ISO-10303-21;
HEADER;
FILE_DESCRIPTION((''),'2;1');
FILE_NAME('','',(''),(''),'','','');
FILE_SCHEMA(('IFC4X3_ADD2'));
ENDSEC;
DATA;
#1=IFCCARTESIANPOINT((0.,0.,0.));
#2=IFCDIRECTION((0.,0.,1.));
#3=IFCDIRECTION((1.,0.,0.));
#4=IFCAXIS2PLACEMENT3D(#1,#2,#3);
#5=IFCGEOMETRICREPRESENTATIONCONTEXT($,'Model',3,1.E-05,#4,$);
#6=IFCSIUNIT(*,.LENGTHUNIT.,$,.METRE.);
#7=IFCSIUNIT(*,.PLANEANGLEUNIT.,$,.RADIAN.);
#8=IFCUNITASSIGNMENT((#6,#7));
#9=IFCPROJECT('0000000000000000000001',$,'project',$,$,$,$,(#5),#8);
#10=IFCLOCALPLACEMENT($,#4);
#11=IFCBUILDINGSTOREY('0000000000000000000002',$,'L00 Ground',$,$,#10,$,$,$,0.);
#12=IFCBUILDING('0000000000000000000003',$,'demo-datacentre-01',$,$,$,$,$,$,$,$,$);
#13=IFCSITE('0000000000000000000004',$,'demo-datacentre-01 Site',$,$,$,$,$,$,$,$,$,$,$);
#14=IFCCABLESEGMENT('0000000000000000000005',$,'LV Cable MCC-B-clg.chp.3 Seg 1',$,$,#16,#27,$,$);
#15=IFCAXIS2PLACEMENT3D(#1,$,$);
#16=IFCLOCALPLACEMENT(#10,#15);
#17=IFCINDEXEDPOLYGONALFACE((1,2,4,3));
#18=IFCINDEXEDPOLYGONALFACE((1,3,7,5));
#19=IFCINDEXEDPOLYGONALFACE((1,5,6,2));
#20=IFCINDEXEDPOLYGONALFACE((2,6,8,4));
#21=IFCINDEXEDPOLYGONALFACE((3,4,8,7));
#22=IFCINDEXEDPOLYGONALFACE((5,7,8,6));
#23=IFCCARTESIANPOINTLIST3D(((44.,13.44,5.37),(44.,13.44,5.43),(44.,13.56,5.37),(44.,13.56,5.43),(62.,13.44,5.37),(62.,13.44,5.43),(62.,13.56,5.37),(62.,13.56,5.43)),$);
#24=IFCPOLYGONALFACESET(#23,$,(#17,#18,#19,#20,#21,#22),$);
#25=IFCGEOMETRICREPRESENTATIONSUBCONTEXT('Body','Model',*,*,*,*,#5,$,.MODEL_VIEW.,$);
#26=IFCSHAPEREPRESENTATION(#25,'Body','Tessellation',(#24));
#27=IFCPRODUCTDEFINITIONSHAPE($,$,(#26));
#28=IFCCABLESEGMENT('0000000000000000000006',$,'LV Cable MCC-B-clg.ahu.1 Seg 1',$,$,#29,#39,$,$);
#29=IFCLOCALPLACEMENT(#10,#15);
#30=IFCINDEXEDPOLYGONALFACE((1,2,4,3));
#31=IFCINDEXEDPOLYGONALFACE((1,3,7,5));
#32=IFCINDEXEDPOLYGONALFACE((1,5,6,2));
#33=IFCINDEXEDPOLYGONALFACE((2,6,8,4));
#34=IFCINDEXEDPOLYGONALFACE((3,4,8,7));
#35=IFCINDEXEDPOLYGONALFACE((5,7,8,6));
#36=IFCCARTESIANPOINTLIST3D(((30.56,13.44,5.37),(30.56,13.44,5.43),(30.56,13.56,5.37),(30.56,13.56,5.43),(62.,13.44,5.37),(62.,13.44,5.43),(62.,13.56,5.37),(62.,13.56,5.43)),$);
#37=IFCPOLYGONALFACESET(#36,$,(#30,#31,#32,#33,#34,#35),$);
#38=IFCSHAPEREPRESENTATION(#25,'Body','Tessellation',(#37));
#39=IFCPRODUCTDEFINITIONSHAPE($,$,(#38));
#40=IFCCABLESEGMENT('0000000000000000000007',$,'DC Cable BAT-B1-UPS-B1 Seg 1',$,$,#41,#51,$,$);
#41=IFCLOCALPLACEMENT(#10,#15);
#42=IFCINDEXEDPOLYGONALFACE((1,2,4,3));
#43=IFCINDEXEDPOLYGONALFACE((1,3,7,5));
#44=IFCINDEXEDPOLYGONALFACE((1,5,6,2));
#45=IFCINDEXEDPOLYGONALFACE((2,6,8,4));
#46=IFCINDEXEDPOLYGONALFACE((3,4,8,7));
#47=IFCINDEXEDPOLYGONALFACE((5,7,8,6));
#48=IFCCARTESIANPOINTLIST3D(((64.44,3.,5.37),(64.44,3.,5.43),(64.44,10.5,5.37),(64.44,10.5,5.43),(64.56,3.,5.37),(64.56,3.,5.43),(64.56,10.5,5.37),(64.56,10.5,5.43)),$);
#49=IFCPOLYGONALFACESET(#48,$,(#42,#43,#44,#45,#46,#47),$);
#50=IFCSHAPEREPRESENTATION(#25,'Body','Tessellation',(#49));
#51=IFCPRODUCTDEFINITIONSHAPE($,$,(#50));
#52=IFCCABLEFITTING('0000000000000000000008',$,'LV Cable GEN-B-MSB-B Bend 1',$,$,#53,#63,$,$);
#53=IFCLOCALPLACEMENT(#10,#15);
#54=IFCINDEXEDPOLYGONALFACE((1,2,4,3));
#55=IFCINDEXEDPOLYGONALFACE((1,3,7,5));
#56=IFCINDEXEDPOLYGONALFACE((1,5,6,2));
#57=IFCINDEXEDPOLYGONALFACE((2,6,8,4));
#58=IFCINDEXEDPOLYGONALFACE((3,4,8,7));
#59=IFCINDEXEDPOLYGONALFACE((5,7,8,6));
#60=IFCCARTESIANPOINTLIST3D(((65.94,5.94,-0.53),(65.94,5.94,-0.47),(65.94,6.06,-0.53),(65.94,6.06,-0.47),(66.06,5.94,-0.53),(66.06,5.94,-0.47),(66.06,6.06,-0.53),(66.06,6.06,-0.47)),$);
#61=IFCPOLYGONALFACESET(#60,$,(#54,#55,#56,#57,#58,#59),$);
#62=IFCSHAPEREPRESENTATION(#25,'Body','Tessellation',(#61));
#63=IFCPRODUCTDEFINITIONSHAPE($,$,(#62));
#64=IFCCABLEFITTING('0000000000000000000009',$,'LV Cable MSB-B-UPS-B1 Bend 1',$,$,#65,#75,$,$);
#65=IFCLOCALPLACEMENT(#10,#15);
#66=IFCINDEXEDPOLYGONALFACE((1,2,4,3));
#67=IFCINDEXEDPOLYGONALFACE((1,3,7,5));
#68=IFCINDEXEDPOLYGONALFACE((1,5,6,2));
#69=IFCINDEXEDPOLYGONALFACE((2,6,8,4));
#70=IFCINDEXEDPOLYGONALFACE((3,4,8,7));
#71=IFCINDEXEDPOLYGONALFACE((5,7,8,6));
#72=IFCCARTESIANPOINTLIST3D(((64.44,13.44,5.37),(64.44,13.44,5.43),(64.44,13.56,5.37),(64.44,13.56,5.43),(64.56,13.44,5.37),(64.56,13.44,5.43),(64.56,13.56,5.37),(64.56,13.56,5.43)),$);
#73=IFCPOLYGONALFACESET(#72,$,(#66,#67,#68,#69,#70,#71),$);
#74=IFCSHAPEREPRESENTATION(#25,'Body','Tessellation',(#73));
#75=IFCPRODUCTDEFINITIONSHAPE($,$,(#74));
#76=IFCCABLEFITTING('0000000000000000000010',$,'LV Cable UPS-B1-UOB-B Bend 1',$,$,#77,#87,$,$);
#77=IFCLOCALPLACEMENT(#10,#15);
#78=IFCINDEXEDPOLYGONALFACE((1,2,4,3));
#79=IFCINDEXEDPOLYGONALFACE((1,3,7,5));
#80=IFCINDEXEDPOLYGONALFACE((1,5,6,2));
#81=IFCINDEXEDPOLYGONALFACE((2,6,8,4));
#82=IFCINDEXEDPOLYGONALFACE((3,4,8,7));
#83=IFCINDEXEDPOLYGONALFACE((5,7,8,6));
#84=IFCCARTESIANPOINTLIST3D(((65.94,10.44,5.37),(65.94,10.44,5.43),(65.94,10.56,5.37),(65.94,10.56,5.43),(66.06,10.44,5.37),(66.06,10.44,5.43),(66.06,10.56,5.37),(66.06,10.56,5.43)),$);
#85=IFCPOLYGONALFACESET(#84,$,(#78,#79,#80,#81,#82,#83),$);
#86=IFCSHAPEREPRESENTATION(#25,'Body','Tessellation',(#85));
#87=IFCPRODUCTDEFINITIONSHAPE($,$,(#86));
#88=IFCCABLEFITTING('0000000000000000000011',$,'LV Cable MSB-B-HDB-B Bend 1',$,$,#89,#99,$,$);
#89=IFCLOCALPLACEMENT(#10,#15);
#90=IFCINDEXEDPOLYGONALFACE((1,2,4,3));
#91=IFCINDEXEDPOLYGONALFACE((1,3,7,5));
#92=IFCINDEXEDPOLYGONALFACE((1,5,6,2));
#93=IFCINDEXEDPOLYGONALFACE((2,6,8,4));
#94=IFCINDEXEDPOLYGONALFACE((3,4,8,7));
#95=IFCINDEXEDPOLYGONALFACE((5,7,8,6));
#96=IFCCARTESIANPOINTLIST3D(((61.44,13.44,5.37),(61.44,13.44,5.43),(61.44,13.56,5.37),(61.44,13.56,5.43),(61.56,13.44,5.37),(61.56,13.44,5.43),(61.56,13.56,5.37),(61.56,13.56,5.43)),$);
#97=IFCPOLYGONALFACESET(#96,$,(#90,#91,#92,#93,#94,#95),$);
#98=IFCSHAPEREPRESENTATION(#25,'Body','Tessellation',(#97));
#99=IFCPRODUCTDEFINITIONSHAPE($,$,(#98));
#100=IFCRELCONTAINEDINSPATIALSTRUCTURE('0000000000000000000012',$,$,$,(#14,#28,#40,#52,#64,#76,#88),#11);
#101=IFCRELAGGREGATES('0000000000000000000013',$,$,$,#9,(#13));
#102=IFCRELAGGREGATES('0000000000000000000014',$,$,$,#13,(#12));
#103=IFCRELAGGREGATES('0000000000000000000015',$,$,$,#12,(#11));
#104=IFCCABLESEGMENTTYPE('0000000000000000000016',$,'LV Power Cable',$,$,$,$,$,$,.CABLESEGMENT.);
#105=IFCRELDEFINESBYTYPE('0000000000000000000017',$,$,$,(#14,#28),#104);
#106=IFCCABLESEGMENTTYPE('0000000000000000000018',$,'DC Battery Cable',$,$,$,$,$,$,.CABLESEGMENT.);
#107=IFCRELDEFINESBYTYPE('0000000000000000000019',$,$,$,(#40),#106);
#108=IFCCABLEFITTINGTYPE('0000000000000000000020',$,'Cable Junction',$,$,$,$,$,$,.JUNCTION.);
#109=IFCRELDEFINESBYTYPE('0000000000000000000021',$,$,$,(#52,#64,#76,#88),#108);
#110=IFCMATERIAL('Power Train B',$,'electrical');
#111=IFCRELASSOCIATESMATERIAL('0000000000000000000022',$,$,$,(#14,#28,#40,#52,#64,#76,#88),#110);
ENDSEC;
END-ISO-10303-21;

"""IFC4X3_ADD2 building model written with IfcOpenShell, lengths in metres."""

from ifc_helpers import new_model, si_unit, frame, origin_with_axes, place, context, subcontext, project, spatial, rectangle, extrude, material, type_object, element, save


model = new_model("IFC4X3_ADD2")

# Units and contexts
model_context = context("Model", 3, precision=1e-05, world=origin_with_axes())
body_context = subcontext(model_context, "Body", "Model", "MODEL_VIEW")
ifc_project = project(units=[si_unit("LENGTHUNIT", "METRE"), si_unit("PLANEANGLEUNIT", "RADIAN")], contexts=[model_context])

# Site, building, storey
site = spatial("IfcSite", under=ifc_project, Name="demo-datacentre-01 Site")
building = spatial("IfcBuilding", under=site, Name="demo-datacentre-01")
storey_placement = place(None, origin_with_axes())
storey = spatial("IfcBuildingStorey", under=building, at=storey_placement, Name="L00 Ground", Elevation=0.0)

# Shared definitions
ifc_material = material(Name="Power Train B", Category="electrical")

# Cable segments
cable_segment_type_1 = type_object("IfcCableSegmentType", Name="LV Power Cable", PredefinedType="CABLESEGMENT")
cable_segment_1_placement = place(storey_placement, frame((62.0, 13.5, 5.4), z_axis=(-1.0, 0.0, 0.0), x_axis=(0.0, -1.0, 0.0)))
element("IfcCableSegment", 1, at=cable_segment_1_placement, inside=storey, type_object=cable_segment_type_1, material=ifc_material, Name="LV Cable MCC-B-clg.chp.3 Seg 1", context=body_context, shape_type="SweptSolid", body=[
    extrude(rectangle(XDim=0.12, YDim=0.06), origin_with_axes(), (0.0, 0.0, 1.0), 18.0),
])
cable_segment_2_placement = place(storey_placement, frame((62.0, 13.5, 5.4), z_axis=(-1.0, 0.0, 0.0), x_axis=(0.0, -1.0, 0.0)))
element("IfcCableSegment", 2, at=cable_segment_2_placement, inside=storey, type_object=cable_segment_type_1, material=ifc_material, Name="LV Cable MCC-B-clg.ahu.1 Seg 1", context=body_context, shape_type="SweptSolid", body=[
    extrude(rectangle(XDim=0.12, YDim=0.06), origin_with_axes(), (0.0, 0.0, 1.0), 31.44),
])
cable_segment_type_2 = type_object("IfcCableSegmentType", Name="DC Battery Cable", PredefinedType="CABLESEGMENT")
cable_segment_3_placement = place(storey_placement, frame((64.5, 3.0, 5.4), z_axis=(0.0, 1.0, 0.0), x_axis=(-1.0, 0.0, 0.0)))
element("IfcCableSegment", 3, at=cable_segment_3_placement, inside=storey, type_object=cable_segment_type_2, material=ifc_material, Name="DC Cable BAT-B1-UPS-B1 Seg 1", context=body_context, shape_type="SweptSolid", body=[
    extrude(rectangle(XDim=0.12, YDim=0.06), origin_with_axes(), (0.0, 0.0, 1.0), 7.5),
])

# Cable fittings
cable_fitting_type = type_object("IfcCableFittingType", Name="Cable Junction", PredefinedType="JUNCTION")
for number, where, z_axis, x_axis, name in (
    (4, (66.0, 6.0, -0.53), (0.0, 0.0, 1.0), (1.0, 0.0, 0.0), "LV Cable GEN-B-MSB-B Bend 1"),
    (5, (64.5, 13.5, 5.37), (0.0, 0.0, 1.0), (1.0, 0.0, 0.0), "LV Cable MSB-B-UPS-B1 Bend 1"),
    (6, (66.0, 10.5, 5.37), (0.0, 0.0, 1.0), (1.0, 0.0, 0.0), "LV Cable UPS-B1-UOB-B Bend 1"),
    (7, (61.5, 13.5, 5.37), (0.0, 0.0, 1.0), (1.0, 0.0, 0.0), "LV Cable MSB-B-HDB-B Bend 1"),
):
    element("IfcCableFitting", number, at=place(storey_placement, frame(where, z_axis=z_axis, x_axis=x_axis)), inside=storey, type_object=cable_fitting_type, material=ifc_material, Name=name, context=body_context, shape_type="SweptSolid", body=[
        extrude(rectangle(XDim=0.12, YDim=0.12), origin_with_axes(), (0.0, 0.0, 1.0), 0.06),
    ])

save(model, "model.ifc")
